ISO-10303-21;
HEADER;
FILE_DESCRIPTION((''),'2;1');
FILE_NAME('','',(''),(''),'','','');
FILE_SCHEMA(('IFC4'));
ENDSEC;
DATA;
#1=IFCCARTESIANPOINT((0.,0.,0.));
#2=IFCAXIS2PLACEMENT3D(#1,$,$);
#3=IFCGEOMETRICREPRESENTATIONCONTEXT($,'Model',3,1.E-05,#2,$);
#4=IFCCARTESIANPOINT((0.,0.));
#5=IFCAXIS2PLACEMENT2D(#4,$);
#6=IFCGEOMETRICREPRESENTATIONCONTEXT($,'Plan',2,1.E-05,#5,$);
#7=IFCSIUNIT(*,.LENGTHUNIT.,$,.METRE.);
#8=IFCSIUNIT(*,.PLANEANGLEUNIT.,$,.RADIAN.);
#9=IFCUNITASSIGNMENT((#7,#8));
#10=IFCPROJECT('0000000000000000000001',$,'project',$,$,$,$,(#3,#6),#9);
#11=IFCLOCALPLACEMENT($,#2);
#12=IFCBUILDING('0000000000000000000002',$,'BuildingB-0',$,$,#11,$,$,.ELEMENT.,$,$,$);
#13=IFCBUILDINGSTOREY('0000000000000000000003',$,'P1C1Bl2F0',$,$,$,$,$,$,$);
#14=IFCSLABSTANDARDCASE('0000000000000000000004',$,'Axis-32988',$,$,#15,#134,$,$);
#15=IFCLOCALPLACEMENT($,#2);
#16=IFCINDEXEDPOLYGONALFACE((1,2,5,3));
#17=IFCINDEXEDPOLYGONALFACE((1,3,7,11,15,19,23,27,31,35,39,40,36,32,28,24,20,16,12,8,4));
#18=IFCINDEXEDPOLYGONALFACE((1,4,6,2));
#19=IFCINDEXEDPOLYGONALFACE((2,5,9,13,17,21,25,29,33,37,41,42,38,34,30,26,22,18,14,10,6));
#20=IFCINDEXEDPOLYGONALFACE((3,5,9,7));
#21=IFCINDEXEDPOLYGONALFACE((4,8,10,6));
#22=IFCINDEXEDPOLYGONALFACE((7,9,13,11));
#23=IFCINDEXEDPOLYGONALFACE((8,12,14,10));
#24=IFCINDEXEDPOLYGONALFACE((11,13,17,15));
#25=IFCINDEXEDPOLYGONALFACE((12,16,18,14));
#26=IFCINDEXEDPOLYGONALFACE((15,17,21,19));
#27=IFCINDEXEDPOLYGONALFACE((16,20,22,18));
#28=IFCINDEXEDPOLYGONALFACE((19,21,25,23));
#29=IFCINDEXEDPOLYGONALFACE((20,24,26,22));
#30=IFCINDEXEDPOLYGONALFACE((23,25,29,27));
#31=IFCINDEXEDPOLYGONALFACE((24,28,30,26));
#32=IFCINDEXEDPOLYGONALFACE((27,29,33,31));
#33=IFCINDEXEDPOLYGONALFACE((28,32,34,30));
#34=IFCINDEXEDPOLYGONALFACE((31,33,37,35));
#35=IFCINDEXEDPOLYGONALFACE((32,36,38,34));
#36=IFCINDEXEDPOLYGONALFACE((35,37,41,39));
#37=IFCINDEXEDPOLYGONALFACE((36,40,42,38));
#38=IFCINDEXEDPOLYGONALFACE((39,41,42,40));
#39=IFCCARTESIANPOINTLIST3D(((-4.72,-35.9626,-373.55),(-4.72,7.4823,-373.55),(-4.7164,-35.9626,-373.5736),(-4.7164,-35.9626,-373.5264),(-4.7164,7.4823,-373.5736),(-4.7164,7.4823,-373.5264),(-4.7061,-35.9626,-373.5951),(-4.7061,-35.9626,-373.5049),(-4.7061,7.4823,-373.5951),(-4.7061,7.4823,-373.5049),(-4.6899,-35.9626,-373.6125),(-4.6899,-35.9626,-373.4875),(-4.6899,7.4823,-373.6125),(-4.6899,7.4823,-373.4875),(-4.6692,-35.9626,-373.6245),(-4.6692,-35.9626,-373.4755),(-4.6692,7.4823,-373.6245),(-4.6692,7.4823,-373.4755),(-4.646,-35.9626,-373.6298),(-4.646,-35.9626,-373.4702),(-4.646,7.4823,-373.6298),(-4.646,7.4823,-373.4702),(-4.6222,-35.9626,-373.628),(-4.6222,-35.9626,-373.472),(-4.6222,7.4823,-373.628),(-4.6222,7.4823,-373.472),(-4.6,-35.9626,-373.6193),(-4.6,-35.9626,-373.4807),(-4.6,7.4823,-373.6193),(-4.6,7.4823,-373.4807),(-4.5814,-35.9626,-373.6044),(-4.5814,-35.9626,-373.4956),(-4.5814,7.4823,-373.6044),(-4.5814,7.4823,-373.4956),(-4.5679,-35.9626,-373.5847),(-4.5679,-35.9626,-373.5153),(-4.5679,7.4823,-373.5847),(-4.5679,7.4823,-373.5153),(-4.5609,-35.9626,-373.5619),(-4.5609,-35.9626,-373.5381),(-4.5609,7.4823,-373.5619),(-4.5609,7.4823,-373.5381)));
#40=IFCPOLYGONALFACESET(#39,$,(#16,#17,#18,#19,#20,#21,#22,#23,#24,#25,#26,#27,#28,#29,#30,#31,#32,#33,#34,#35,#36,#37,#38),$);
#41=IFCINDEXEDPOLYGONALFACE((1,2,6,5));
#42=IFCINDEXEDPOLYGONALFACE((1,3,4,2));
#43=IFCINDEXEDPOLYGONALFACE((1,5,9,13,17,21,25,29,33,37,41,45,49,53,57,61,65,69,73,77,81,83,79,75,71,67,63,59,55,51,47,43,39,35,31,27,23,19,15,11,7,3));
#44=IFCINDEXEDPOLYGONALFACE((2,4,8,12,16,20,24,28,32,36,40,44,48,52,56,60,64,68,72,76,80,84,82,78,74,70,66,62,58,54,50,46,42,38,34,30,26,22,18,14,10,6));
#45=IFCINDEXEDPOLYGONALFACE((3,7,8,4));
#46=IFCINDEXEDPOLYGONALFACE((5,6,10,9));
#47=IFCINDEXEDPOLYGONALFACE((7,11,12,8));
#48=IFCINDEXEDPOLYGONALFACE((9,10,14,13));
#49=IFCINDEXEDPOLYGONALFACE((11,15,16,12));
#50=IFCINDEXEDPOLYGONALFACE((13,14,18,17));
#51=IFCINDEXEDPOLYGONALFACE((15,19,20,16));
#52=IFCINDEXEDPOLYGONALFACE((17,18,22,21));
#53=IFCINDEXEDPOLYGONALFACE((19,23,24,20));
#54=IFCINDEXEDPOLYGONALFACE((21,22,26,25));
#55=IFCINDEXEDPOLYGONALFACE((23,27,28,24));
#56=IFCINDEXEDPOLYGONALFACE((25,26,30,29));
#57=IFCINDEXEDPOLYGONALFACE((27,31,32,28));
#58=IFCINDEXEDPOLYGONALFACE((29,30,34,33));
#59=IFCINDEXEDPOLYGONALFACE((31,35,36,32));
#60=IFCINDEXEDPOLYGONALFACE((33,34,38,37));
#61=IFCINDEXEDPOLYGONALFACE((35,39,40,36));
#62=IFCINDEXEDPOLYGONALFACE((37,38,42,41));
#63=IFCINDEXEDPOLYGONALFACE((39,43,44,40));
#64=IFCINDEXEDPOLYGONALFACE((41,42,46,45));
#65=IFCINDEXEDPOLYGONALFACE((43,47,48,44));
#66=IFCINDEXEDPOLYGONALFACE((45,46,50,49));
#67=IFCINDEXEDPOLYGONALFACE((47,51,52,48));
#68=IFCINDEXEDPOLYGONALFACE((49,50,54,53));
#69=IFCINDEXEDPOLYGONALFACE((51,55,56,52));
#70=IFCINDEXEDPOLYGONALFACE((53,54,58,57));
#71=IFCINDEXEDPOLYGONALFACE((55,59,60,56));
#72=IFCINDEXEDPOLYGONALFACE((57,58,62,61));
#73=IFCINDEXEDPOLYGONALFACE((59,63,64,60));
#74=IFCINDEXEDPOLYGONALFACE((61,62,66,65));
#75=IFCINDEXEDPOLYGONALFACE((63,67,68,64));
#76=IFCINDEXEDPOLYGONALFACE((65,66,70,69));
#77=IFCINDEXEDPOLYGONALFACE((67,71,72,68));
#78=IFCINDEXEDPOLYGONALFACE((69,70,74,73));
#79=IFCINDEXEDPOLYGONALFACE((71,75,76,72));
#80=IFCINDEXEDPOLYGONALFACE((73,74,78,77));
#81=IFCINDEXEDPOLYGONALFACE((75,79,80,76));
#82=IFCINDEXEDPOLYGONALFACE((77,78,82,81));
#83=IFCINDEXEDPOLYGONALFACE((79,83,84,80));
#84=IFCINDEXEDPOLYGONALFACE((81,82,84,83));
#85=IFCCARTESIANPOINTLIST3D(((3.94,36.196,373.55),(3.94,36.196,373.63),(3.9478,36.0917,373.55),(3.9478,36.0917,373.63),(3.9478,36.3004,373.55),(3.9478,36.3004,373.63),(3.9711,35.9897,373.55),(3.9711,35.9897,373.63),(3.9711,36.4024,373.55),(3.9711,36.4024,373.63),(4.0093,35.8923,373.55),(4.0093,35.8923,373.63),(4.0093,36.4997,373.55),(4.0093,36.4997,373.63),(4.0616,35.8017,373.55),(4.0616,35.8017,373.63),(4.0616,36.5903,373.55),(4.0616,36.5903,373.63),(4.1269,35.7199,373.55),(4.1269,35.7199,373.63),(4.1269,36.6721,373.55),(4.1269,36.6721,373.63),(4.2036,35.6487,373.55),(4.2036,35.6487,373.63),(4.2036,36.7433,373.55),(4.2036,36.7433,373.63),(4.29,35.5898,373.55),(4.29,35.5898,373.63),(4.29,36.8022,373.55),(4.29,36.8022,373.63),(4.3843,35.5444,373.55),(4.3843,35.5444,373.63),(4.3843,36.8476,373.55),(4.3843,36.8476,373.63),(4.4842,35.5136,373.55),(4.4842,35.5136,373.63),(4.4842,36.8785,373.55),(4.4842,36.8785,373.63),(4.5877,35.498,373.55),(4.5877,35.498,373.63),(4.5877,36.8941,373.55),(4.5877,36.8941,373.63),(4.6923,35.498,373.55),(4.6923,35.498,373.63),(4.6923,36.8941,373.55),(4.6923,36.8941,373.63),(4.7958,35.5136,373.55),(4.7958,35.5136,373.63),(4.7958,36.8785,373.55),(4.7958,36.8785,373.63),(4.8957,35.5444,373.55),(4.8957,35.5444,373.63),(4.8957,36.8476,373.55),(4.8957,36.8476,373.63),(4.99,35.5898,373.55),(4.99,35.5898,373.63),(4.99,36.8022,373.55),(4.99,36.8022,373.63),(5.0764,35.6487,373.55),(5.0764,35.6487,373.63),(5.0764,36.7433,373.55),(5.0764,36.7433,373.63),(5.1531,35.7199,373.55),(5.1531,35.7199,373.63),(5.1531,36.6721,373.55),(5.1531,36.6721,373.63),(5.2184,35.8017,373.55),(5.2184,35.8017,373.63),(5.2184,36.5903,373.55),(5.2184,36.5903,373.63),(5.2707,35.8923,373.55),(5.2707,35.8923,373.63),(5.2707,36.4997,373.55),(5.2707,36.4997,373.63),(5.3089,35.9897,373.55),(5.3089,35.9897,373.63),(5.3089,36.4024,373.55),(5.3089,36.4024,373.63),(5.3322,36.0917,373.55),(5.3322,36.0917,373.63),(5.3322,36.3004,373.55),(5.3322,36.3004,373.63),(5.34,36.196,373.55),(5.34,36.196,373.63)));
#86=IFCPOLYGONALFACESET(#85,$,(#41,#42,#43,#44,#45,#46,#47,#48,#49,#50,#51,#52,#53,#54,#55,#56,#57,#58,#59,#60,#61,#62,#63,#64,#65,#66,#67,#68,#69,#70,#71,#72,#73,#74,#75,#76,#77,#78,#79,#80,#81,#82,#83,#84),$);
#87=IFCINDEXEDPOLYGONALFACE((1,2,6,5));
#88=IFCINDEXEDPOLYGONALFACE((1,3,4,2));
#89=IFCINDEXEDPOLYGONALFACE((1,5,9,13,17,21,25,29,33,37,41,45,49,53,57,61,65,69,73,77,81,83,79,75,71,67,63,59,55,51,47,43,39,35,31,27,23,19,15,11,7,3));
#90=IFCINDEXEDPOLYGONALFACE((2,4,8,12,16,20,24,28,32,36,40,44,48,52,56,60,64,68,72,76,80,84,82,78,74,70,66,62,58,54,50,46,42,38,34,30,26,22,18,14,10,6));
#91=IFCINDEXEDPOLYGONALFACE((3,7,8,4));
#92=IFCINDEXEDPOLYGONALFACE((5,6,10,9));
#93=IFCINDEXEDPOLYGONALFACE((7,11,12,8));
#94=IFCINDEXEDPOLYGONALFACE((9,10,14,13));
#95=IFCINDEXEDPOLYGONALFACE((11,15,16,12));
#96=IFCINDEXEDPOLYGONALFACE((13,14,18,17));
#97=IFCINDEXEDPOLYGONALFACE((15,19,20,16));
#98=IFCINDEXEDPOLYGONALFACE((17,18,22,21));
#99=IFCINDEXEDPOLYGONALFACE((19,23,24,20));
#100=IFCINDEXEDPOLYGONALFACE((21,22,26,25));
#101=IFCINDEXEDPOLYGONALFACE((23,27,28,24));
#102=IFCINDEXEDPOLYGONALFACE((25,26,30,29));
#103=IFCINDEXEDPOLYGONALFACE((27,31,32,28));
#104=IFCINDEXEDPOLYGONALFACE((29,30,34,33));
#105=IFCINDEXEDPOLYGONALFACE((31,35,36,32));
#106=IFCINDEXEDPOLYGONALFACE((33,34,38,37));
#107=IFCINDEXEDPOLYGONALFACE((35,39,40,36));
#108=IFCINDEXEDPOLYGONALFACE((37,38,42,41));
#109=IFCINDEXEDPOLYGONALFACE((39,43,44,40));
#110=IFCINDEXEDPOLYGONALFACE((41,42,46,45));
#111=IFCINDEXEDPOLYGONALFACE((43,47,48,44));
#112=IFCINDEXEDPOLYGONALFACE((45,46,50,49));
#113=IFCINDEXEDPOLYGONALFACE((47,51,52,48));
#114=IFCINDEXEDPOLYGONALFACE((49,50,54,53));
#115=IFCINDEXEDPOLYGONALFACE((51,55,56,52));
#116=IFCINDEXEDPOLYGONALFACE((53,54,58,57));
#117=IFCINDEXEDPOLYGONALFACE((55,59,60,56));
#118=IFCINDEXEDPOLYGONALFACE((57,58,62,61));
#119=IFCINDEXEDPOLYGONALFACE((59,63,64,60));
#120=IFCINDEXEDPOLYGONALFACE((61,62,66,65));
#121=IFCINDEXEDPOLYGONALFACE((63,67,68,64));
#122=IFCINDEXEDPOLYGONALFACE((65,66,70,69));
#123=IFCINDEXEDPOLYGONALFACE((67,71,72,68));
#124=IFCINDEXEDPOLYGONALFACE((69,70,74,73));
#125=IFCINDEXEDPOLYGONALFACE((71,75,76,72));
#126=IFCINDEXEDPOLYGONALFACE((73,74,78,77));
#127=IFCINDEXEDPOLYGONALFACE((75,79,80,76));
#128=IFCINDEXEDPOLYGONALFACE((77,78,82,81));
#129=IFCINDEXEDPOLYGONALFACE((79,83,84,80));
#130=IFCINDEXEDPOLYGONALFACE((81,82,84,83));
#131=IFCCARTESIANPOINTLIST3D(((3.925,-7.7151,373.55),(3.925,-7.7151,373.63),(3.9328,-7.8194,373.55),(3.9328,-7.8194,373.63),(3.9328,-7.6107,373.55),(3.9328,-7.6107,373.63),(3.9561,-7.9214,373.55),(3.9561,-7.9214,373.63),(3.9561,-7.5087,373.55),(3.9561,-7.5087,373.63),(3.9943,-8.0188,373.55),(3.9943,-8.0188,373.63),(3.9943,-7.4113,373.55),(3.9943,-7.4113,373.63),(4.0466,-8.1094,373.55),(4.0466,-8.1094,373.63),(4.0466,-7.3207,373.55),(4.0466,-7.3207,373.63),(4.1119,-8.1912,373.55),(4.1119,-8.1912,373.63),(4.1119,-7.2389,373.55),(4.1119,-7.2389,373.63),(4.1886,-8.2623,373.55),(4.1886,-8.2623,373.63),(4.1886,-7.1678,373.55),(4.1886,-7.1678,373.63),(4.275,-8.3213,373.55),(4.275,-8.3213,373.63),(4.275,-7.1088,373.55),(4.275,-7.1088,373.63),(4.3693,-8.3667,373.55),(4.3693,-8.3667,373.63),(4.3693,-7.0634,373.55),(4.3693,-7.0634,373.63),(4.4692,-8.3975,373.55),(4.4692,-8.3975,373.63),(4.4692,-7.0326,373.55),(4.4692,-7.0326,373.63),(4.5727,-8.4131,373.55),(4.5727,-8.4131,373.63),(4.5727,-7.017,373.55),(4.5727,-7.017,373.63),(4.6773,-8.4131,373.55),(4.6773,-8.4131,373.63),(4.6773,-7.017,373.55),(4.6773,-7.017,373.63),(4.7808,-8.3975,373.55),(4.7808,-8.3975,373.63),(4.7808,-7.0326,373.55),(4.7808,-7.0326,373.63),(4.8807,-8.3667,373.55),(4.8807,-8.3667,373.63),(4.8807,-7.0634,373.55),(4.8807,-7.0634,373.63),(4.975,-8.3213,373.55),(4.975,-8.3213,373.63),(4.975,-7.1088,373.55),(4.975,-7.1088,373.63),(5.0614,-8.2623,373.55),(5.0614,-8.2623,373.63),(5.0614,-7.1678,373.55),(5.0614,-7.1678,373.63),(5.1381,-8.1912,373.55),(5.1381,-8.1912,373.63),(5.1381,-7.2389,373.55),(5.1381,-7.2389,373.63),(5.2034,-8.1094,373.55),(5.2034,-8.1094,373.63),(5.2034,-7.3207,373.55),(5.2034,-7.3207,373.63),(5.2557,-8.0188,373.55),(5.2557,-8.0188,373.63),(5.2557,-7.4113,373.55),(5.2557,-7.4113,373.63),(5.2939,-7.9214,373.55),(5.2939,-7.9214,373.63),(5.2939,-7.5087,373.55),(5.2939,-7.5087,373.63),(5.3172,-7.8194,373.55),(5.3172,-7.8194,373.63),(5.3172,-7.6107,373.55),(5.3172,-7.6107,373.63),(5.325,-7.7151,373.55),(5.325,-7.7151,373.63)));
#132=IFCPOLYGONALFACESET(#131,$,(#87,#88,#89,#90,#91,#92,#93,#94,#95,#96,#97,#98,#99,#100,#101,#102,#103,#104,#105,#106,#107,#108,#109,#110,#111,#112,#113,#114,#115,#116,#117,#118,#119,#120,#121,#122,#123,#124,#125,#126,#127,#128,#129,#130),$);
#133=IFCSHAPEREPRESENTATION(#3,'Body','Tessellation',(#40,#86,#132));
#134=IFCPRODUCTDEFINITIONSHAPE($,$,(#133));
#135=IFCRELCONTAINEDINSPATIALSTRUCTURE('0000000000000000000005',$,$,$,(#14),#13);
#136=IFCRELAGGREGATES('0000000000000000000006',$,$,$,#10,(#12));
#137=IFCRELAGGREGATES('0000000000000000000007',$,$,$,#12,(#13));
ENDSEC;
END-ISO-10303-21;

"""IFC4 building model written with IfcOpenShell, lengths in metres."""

from ifc_helpers import new_model, entity, si_unit, frame, origin, origin_2d, place, context, project, spatial, circle, extrude, element, save


model = new_model("IFC4")

# Units and contexts
model_context = context("Model", 3, precision=1e-05, world=origin())
plan_context = context("Plan", 2, precision=1e-05, world=origin_2d())
ifc_project = project(units=[si_unit("LENGTHUNIT", "METRE"), si_unit("PLANEANGLEUNIT", "RADIAN")], contexts=[model_context, plan_context])

# Building, storey
building_placement = place(None, origin())
building = spatial("IfcBuilding", under=ifc_project, at=building_placement, Name="BuildingB-0", CompositionType="ELEMENT")
storey = spatial("IfcBuildingStorey", under=building, Name="P1C1Bl2F0")

# Slab
element("IfcSlabStandardCase", 1, inside=storey, Name="Axis-32988", context=model_context, shape_type="AdvancedSweptSolid", body=[
    entity("IfcSurfaceCurveSweptAreaSolid", entity("IfcCircleProfileDef", "AREA", None, None, 0.08), None, entity("IfcPolyline", [entity("IfcCartesianPoint", [4.64, 35.9626, 373.55]), entity("IfcCartesianPoint", [4.64, -7.4823, 373.55])]), None, None, entity("IfcPlane", entity("IfcAxis2Placement3D", entity("IfcCartesianPoint", [4.64, 35.9626, 373.55]), entity("IfcDirection", [0.0, 0.0, 1.0]), entity("IfcDirection", [1.0, 0.0, 0.0])))),
    extrude(circle(Radius=0.7), frame((4.64, 36.196, 373.55)), (0.0, 0.0, 1.0), 0.08),
    extrude(circle(Radius=0.7), frame((4.625, -7.7151, 373.55)), (0.0, 0.0, 1.0), 0.08),
])

save(model, "model.ifc")
